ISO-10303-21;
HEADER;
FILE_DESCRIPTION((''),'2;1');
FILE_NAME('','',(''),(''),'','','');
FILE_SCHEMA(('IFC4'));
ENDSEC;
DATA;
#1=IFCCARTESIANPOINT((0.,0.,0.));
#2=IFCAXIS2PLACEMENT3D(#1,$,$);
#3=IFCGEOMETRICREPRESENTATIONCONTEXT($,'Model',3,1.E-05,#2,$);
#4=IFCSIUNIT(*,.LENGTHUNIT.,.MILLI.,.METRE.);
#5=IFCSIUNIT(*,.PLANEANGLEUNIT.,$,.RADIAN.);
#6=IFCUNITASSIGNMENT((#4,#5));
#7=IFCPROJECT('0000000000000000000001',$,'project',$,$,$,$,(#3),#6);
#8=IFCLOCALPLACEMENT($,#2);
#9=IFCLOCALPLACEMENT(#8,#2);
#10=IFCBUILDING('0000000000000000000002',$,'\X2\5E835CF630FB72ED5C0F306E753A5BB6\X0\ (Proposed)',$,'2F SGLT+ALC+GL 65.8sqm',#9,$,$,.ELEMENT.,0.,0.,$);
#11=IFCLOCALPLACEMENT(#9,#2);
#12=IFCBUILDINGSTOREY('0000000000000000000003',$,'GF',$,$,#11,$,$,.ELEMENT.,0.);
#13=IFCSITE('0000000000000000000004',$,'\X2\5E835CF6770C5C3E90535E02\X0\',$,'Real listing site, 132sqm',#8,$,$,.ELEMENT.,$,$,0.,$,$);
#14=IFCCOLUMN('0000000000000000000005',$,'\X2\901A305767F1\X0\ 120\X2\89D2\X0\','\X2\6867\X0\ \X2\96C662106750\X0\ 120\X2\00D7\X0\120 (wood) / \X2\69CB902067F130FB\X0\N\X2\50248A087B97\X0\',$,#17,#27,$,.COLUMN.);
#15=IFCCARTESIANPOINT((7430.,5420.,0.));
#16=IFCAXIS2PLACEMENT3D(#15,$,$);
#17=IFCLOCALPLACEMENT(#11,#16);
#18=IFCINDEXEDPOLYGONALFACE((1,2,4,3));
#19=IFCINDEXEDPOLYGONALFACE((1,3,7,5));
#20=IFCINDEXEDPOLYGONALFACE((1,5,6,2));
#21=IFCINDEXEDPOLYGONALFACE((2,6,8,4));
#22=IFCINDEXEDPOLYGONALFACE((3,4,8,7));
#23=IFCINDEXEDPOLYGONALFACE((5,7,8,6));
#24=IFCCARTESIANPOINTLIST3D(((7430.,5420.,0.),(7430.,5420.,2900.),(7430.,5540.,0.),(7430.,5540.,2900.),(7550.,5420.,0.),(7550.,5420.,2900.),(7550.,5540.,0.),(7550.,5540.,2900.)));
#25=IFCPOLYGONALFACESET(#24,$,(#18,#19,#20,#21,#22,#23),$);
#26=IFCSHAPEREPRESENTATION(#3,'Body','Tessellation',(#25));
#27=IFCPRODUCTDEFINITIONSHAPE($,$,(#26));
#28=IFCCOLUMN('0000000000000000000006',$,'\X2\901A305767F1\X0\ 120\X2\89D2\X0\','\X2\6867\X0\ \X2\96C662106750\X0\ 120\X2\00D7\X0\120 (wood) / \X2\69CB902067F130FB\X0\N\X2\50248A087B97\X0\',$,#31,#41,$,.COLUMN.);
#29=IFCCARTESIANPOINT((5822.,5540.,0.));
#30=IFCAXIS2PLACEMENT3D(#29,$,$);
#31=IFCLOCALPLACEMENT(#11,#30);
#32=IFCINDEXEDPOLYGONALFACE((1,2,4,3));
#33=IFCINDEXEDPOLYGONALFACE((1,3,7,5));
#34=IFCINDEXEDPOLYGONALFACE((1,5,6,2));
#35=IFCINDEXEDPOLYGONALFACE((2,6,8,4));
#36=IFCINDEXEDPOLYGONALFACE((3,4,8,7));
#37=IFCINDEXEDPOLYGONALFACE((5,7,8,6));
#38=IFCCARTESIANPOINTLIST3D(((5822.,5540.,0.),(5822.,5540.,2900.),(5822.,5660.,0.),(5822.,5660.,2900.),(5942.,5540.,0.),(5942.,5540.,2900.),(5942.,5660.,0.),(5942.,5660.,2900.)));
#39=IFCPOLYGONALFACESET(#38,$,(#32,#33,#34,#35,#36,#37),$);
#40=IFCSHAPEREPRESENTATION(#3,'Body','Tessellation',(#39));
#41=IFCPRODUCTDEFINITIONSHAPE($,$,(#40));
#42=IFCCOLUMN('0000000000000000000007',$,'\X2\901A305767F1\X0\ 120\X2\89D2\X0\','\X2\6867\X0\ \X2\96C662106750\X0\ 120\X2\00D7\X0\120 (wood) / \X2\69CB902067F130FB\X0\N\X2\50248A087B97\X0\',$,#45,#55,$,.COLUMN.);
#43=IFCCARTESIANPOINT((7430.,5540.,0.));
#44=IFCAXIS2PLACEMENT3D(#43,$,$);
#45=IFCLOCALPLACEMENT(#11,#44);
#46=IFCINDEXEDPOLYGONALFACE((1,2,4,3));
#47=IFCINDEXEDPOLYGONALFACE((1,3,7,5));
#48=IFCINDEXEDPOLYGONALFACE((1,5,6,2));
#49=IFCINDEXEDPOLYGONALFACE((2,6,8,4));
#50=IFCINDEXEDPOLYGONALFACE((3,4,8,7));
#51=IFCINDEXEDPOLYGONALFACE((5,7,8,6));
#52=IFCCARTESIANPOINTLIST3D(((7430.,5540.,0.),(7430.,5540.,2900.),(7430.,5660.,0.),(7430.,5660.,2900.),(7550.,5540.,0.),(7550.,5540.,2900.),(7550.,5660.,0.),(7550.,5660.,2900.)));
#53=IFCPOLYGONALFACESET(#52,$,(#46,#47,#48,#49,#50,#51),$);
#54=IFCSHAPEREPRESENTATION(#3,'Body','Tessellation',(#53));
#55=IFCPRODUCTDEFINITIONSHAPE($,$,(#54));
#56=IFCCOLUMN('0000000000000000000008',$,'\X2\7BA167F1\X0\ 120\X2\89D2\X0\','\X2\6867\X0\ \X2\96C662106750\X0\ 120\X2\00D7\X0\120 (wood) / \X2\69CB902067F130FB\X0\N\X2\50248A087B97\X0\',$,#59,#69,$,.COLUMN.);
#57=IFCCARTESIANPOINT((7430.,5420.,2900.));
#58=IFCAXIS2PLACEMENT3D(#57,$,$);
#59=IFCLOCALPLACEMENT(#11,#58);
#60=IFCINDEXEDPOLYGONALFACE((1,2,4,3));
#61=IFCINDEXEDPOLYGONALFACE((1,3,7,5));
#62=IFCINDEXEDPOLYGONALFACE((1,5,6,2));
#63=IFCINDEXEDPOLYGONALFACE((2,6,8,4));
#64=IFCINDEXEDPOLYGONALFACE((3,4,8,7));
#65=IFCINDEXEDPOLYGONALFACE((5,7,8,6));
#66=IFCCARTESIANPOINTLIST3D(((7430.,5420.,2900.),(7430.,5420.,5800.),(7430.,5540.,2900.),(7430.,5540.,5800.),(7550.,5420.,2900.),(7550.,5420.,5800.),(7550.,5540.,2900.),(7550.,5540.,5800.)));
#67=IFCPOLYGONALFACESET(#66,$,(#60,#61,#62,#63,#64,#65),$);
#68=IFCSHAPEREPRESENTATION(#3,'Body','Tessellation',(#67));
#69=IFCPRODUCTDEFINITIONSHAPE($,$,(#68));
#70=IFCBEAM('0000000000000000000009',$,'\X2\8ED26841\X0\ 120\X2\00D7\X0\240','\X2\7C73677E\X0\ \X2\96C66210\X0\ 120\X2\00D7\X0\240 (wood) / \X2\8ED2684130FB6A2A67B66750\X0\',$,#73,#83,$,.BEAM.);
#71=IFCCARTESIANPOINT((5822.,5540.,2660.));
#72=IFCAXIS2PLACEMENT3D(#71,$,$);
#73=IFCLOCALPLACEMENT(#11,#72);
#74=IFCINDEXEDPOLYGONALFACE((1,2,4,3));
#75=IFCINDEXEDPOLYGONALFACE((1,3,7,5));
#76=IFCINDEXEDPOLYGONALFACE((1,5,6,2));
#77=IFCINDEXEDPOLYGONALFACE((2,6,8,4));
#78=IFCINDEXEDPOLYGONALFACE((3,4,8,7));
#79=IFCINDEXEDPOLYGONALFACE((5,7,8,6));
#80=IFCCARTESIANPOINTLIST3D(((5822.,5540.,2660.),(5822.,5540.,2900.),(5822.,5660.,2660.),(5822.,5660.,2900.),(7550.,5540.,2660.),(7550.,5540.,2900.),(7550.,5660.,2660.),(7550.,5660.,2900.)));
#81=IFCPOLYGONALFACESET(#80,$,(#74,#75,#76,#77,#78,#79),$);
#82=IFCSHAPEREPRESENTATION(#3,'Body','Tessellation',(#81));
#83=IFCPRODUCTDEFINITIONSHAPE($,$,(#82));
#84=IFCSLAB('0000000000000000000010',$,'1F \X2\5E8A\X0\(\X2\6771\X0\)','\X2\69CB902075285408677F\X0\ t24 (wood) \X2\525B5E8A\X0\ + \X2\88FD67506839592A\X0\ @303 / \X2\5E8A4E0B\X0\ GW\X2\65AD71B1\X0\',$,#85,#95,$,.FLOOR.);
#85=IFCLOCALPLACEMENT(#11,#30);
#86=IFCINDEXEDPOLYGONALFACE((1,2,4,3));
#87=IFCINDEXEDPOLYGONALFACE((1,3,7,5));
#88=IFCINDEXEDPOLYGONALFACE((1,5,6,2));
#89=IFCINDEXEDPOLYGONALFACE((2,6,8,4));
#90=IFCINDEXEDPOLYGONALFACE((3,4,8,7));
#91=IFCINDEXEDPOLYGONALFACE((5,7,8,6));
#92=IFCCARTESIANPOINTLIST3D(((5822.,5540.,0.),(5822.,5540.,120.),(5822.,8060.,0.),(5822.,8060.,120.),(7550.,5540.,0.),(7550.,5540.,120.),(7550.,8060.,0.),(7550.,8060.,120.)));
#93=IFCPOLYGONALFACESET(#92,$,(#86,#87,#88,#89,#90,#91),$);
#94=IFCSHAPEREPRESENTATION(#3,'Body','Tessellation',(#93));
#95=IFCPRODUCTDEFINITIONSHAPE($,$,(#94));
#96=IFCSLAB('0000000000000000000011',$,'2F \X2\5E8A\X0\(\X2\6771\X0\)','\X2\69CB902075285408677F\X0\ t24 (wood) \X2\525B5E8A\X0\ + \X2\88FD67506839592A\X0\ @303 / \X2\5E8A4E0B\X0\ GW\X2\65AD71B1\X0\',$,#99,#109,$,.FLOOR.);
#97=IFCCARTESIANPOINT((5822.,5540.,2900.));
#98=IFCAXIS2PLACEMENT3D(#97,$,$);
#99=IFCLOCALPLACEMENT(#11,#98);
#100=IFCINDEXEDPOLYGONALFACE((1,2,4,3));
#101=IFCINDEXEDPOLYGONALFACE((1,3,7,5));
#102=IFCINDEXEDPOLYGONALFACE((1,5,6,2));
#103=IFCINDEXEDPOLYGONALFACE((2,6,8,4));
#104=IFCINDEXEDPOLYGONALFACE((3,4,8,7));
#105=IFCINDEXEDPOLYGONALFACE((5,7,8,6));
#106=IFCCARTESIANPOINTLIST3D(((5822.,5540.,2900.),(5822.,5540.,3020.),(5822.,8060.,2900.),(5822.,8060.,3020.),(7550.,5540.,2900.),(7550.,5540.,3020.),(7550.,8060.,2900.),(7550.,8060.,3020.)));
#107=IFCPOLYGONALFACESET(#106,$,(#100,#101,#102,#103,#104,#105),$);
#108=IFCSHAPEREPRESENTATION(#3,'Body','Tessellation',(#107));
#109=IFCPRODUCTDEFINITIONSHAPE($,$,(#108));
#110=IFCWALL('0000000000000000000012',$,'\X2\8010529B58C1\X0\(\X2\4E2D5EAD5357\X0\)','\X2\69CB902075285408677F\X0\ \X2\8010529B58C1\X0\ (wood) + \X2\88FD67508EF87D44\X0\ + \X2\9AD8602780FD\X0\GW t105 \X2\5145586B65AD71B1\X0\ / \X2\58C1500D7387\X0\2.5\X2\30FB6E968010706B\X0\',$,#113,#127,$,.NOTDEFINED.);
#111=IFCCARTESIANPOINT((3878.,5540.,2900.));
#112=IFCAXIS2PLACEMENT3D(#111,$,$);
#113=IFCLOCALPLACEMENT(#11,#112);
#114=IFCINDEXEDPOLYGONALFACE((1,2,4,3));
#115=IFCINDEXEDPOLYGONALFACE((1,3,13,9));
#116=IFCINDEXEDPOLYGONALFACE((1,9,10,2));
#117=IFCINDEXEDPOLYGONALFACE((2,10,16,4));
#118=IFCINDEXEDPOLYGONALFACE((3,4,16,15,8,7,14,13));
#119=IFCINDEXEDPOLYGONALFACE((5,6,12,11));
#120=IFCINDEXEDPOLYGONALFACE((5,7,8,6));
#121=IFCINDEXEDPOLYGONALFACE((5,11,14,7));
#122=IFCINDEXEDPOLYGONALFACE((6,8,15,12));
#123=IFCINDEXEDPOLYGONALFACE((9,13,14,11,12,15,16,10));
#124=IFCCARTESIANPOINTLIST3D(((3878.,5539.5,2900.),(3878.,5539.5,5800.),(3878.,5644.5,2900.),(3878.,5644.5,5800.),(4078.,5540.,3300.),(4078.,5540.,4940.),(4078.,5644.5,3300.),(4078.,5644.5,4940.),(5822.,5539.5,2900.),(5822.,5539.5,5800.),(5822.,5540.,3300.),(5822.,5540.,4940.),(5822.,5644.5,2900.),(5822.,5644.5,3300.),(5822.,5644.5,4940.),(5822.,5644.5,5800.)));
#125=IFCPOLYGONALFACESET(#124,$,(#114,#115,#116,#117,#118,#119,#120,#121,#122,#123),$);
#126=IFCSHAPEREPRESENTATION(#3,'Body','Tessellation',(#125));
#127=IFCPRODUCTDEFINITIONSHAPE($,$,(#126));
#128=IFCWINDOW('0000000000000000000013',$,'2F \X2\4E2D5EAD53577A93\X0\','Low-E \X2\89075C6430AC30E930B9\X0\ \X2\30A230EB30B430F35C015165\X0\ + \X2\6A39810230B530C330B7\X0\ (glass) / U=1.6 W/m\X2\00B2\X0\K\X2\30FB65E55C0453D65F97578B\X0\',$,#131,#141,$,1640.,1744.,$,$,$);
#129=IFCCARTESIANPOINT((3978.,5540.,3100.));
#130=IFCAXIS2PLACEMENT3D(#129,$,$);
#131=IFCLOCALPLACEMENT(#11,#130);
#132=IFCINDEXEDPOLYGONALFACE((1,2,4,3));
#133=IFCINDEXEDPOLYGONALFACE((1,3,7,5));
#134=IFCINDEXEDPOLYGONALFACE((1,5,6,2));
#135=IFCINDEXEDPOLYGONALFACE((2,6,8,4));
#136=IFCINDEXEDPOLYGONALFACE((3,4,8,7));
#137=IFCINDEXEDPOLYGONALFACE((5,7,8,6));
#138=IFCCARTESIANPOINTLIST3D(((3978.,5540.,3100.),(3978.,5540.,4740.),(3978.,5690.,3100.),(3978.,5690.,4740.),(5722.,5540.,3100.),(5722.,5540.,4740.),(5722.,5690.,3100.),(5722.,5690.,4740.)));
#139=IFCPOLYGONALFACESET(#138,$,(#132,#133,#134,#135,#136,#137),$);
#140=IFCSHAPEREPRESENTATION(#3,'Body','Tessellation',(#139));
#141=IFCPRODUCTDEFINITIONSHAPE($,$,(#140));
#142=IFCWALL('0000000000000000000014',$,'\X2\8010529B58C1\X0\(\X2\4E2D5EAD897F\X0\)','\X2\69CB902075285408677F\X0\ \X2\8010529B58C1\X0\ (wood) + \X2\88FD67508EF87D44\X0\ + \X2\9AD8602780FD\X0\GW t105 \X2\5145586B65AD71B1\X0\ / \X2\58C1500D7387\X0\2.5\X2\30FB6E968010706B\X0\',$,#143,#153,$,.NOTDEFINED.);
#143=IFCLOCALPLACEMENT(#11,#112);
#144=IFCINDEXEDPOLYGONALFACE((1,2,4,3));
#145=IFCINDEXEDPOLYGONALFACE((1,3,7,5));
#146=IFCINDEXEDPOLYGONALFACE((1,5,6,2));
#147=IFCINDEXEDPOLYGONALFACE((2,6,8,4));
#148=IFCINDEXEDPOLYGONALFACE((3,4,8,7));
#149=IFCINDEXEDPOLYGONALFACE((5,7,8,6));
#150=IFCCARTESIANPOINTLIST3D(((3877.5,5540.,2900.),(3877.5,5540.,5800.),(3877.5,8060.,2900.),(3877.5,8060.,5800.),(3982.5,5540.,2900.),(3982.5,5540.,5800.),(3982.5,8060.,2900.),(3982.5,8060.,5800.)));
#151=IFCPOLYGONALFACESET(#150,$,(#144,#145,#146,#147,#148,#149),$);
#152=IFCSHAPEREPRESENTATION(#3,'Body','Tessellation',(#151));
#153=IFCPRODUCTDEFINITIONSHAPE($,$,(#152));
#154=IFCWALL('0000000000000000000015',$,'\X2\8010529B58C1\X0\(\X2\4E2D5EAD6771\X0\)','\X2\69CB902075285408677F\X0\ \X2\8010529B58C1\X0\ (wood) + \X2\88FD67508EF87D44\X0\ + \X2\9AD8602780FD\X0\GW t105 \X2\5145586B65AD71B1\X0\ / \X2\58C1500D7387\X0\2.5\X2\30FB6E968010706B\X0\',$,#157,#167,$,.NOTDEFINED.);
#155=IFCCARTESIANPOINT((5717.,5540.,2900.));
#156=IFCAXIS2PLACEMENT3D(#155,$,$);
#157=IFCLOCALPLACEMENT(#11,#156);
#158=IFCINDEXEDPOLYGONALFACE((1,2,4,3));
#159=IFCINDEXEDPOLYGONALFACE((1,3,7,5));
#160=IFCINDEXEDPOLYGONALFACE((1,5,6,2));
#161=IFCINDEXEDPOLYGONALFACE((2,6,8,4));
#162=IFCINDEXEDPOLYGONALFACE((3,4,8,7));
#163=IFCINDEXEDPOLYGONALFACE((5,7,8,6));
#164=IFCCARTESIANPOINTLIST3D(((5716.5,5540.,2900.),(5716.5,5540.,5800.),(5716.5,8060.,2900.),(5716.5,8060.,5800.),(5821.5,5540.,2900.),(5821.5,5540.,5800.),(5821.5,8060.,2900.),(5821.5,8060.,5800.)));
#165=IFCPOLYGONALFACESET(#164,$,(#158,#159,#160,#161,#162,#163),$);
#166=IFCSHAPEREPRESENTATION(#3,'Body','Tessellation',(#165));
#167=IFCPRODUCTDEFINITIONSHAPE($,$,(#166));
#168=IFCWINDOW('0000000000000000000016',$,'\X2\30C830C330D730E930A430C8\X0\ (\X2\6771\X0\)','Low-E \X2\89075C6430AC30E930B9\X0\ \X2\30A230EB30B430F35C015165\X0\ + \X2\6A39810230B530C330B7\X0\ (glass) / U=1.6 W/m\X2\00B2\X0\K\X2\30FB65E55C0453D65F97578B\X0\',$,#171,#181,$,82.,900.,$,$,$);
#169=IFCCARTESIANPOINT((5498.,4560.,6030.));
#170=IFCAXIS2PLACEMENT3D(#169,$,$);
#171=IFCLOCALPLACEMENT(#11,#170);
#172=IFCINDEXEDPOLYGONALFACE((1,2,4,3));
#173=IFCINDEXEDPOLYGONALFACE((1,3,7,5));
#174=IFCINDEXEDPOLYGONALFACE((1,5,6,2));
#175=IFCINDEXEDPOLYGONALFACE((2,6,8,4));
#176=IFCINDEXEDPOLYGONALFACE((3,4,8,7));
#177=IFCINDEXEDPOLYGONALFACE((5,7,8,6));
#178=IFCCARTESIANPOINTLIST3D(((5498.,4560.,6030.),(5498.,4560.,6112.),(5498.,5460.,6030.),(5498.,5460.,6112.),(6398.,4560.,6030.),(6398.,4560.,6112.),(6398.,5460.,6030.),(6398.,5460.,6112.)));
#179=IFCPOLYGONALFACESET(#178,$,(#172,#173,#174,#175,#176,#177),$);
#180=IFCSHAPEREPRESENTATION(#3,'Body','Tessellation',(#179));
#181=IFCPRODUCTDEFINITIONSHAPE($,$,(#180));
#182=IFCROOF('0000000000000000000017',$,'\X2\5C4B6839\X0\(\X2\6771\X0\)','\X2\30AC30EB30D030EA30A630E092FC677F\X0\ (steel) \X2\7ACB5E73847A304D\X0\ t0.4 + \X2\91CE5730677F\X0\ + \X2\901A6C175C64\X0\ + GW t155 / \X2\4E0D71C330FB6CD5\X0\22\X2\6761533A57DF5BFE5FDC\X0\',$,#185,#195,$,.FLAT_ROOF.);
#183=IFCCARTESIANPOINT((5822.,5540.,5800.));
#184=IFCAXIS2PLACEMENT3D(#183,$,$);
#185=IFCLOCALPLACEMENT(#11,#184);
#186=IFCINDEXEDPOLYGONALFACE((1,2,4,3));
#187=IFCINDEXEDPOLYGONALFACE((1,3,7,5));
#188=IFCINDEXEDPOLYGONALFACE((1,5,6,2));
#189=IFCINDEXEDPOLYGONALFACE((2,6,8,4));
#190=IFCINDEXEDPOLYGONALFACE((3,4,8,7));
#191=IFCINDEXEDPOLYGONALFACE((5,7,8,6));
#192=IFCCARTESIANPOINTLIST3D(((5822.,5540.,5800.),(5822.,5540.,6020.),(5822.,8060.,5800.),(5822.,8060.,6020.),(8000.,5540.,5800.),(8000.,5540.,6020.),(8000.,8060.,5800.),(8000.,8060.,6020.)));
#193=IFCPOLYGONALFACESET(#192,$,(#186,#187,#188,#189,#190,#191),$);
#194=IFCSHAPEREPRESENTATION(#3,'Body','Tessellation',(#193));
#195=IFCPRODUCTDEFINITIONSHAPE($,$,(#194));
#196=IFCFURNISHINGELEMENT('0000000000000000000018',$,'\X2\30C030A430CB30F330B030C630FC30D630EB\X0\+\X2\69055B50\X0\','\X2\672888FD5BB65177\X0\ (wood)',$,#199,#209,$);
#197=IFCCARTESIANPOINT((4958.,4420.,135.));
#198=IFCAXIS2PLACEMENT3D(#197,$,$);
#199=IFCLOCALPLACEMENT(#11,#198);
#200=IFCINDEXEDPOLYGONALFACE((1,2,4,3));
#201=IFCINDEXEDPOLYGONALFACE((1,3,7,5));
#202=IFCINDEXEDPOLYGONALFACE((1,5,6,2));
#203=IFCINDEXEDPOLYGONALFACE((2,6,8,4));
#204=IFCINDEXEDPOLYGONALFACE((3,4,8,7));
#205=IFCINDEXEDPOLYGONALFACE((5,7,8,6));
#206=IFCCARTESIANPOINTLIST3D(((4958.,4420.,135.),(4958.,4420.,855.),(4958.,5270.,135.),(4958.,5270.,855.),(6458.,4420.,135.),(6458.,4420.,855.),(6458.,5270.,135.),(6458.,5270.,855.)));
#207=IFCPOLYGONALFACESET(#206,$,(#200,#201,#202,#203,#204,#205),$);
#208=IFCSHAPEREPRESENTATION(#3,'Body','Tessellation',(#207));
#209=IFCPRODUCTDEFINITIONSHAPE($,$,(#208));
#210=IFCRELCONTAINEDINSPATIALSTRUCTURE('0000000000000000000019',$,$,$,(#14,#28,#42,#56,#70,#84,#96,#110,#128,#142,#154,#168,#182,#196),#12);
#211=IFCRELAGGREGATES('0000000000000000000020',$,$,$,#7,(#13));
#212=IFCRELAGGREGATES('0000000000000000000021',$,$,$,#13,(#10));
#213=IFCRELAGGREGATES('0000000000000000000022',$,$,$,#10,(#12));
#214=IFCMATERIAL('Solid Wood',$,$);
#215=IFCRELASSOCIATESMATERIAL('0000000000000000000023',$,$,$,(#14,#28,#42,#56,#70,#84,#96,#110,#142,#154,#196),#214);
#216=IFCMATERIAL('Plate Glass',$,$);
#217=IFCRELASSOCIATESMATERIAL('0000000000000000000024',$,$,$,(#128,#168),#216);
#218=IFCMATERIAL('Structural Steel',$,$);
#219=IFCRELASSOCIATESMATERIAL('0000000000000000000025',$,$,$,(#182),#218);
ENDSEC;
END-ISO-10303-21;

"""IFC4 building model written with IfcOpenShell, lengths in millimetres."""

from ifc_helpers import new_model, si_unit, frame, frame_2d, origin, place, context, project, spatial, rectangle, extrude, material, element, fill, save


model = new_model("IFC4")

# Units and contexts
model_context = context("Model", 3, precision=1e-05, world=origin())
ifc_project = project(units=[si_unit("LENGTHUNIT", "METRE", prefix="MILLI"), si_unit("PLANEANGLEUNIT", "RADIAN")], contexts=[model_context])

# Site, building, storey
site_placement = place(None, origin())
site = spatial("IfcSite", under=ifc_project, at=site_placement, Name="広島県尾道市", ObjectType="Real listing site, 132sqm", CompositionType="ELEMENT", RefElevation=0.0)
building_placement = place(site_placement, origin())
building = spatial("IfcBuilding", under=site, at=building_placement, Name="広島・狭小の町家 (Proposed)", ObjectType="2F SGLT+ALC+GL 65.8sqm", CompositionType="ELEMENT", ElevationOfRefHeight=0.0, ElevationOfTerrain=0.0)
storey_placement = place(building_placement, origin())
storey = spatial("IfcBuildingStorey", under=building, at=storey_placement, Name="GF", CompositionType="ELEMENT", Elevation=0.0)

# Columns
ifc_material_1 = material(Name="Solid Wood")
column_1_placement = place(storey_placement, frame((7430.0, 5420.0, 0.0)))
element("IfcColumn", 1, at=column_1_placement, inside=storey, material=ifc_material_1, Name="通し柱 120角", Description="桧 集成材 120×120 (wood) / 構造柱・N値計算", PredefinedType="COLUMN", context=model_context, shape_type="SweptSolid", body=[
    extrude(rectangle(XDim=120.0, YDim=120.0, at=frame_2d((60.0, 60.0))), frame((7430.0, 5420.0, 0.0)), (0.0, 0.0, 1.0), 2900.0),
])
column_2_placement = place(storey_placement, frame((5822.0, 5540.0, 0.0)))
element("IfcColumn", 2, at=column_2_placement, inside=storey, material=ifc_material_1, Name="通し柱 120角", Description="桧 集成材 120×120 (wood) / 構造柱・N値計算", PredefinedType="COLUMN", context=model_context, shape_type="SweptSolid", body=[
    extrude(rectangle(XDim=120.0, YDim=120.0, at=frame_2d((60.0, 60.0))), frame((5822.0, 5540.0, 0.0)), (0.0, 0.0, 1.0), 2900.0),
])
column_3_placement = place(storey_placement, frame((7430.0, 5540.0, 0.0)))
element("IfcColumn", 3, at=column_3_placement, inside=storey, material=ifc_material_1, Name="通し柱 120角", Description="桧 集成材 120×120 (wood) / 構造柱・N値計算", PredefinedType="COLUMN", context=model_context, shape_type="SweptSolid", body=[
    extrude(rectangle(XDim=120.0, YDim=120.0, at=frame_2d((60.0, 60.0))), frame((7430.0, 5540.0, 0.0)), (0.0, 0.0, 1.0), 2900.0),
])
column_4_placement = place(storey_placement, frame((7430.0, 5420.0, 2900.0)))
element("IfcColumn", 4, at=column_4_placement, inside=storey, material=ifc_material_1, Name="管柱 120角", Description="桧 集成材 120×120 (wood) / 構造柱・N値計算", PredefinedType="COLUMN", context=model_context, shape_type="SweptSolid", body=[
    extrude(rectangle(XDim=120.0, YDim=120.0, at=frame_2d((60.0, 60.0))), frame((7430.0, 5420.0, 2900.0)), (0.0, 0.0, 1.0), 2900.0),
])

# Beam
beam_1_placement = place(storey_placement, frame((5822.0, 5540.0, 2660.0)))
element("IfcBeam", 5, at=beam_1_placement, inside=storey, material=ifc_material_1, Name="軒桁 120×240", Description="米松 集成 120×240 (wood) / 軒桁・横架材", PredefinedType="BEAM", context=model_context, shape_type="SweptSolid", body=[
    extrude(rectangle(XDim=1728.0, YDim=120.0, at=frame_2d((864.0, 60.0))), frame((5822.0, 5540.0, 2660.0)), (0.0, 0.0, 1.0), 240.0),
])

# Slabs
slab_1_placement = place(storey_placement, frame((5822.0, 5540.0, 0.0)))
element("IfcSlab", 6, at=slab_1_placement, inside=storey, material=ifc_material_1, Name="1F 床(東)", Description="構造用合板 t24 (wood) 剛床 + 製材根太 @303 / 床下 GW断熱", PredefinedType="FLOOR", context=model_context, shape_type="SweptSolid", body=[
    extrude(rectangle(XDim=1728.0, YDim=2520.0, at=frame_2d((864.0, 1260.0))), frame((5822.0, 5540.0, 0.0)), (0.0, 0.0, 1.0), 120.0),
])
slab_2_placement = place(storey_placement, frame((5822.0, 5540.0, 2900.0)))
element("IfcSlab", 7, at=slab_2_placement, inside=storey, material=ifc_material_1, Name="2F 床(東)", Description="構造用合板 t24 (wood) 剛床 + 製材根太 @303 / 床下 GW断熱", PredefinedType="FLOOR", context=model_context, shape_type="SweptSolid", body=[
    extrude(rectangle(XDim=1728.0, YDim=2520.0, at=frame_2d((864.0, 1260.0))), frame((5822.0, 5540.0, 2900.0)), (0.0, 0.0, 1.0), 120.0),
])

# Wall, opening, window
wall_1_placement = place(storey_placement, frame((3878.0, 5540.0, 2900.0)))
wall_1 = element("IfcWall", 8, at=wall_1_placement, inside=storey, material=ifc_material_1, Name="耐力壁(中庭南)", Description="構造用合板 耐力壁 (wood) + 製材軸組 + 高性能GW t105 充填断熱 / 壁倍率2.5・準耐火", PredefinedType="NOTDEFINED", context=model_context, shape_type="SweptSolid", body=[
    extrude(rectangle(XDim=1944.0, YDim=105.0, at=frame_2d((972.0, 52.0))), frame((3878.0, 5540.0, 2900.0)), (0.0, 0.0, 1.0), 2900.0),
])
opening_placement = place(storey_placement, frame((3978.0, 5540.0, 3100.0)))
opening = element("IfcOpeningElement", 9, at=opening_placement, cuts=wall_1, PredefinedType="NOTDEFINED", context=model_context, shape_type="SweptSolid", body=[
    extrude(rectangle(XDim=1744.0, YDim=150.0, at=frame_2d((872.0, 75.0))), frame((3978.0, 5540.0, 3100.0)), (0.0, 0.0, 1.0), 1640.0),
])
ifc_material_2 = material(Name="Plate Glass")
window_1_placement = place(storey_placement, frame((3978.0, 5540.0, 3100.0)))
window_1 = element("IfcWindow", 10, at=window_1_placement, inside=storey, material=ifc_material_2, Name="2F 中庭南窓", Description="Low-E 複層ガラス アルゴン封入 + 樹脂サッシ (glass) / U=1.6 W/m²K・日射取得型", OverallHeight=1640.0, OverallWidth=1744.0, context=model_context, shape_type="SweptSolid", body=[
    extrude(rectangle(XDim=1744.0, YDim=150.0, at=frame_2d((872.0, 75.0))), frame((3978.0, 5540.0, 3100.0)), (0.0, 0.0, 1.0), 1640.0),
])
fill(opening, window_1)

# Walls
wall_2_placement = place(storey_placement, frame((3878.0, 5540.0, 2900.0)))
element("IfcWall", 11, at=wall_2_placement, inside=storey, material=ifc_material_1, Name="耐力壁(中庭西)", Description="構造用合板 耐力壁 (wood) + 製材軸組 + 高性能GW t105 充填断熱 / 壁倍率2.5・準耐火", PredefinedType="NOTDEFINED", context=model_context, shape_type="SweptSolid", body=[
    extrude(rectangle(XDim=105.0, YDim=2520.0, at=frame_2d((52.0, 1260.0))), frame((3878.0, 5540.0, 2900.0)), (0.0, 0.0, 1.0), 2900.0),
])
wall_3_placement = place(storey_placement, frame((5717.0, 5540.0, 2900.0)))
element("IfcWall", 12, at=wall_3_placement, inside=storey, material=ifc_material_1, Name="耐力壁(中庭東)", Description="構造用合板 耐力壁 (wood) + 製材軸組 + 高性能GW t105 充填断熱 / 壁倍率2.5・準耐火", PredefinedType="NOTDEFINED", context=model_context, shape_type="SweptSolid", body=[
    extrude(rectangle(XDim=105.0, YDim=2520.0, at=frame_2d((52.0, 1260.0))), frame((5717.0, 5540.0, 2900.0)), (0.0, 0.0, 1.0), 2900.0),
])

# Window
window_2_placement = place(storey_placement, frame((5498.0, 4560.0, 6030.0)))
element("IfcWindow", 13, at=window_2_placement, inside=storey, material=ifc_material_2, Name="トップライト (東)", Description="Low-E 複層ガラス アルゴン封入 + 樹脂サッシ (glass) / U=1.6 W/m²K・日射取得型", OverallHeight=82.0, OverallWidth=900.0, context=model_context, shape_type="SweptSolid", body=[
    extrude(rectangle(XDim=900.0, YDim=900.0, at=frame_2d((450.0, 450.0))), frame((5498.0, 4560.0, 6030.0)), (0.0, 0.0, 1.0), 82.0),
])

# Roof
ifc_material_3 = material(Name="Structural Steel")
for number, where, name in (
    (14, (5822.0, 5540.0, 5800.0), "屋根(東)"),
):
    element("IfcRoof", number, at=place(storey_placement, frame(where)), inside=storey, material=ifc_material_3, Name=name, Description="ガルバリウム鋼板 (steel) 立平葺き t0.4 + 野地板 + 通気層 + GW t155 / 不燃・法22条区域対応", PredefinedType="FLAT_ROOF", context=model_context, shape_type="SweptSolid", body=[
        extrude(rectangle(XDim=2178.0, YDim=2520.0, at=frame_2d((1089.0, 1260.0))), frame((5822.0, 5540.0, 5800.0)), (0.0, 0.0, 1.0), 220.0),
    ])

# Furnishing element
furnishing_1_placement = place(storey_placement, frame((4958.0, 4420.0, 135.0)))
element("IfcFurnishingElement", 15, at=furnishing_1_placement, inside=storey, material=ifc_material_1, Name="ダイニングテーブル+椅子", Description="木製家具 (wood)", context=model_context, shape_type="SweptSolid", body=[
    extrude(rectangle(XDim=1500.0, YDim=850.0, at=frame_2d((750.0, 425.0))), frame((4958.0, 4420.0, 135.0)), (0.0, 0.0, 1.0), 720.0),
])

save(model, "model.ifc")
